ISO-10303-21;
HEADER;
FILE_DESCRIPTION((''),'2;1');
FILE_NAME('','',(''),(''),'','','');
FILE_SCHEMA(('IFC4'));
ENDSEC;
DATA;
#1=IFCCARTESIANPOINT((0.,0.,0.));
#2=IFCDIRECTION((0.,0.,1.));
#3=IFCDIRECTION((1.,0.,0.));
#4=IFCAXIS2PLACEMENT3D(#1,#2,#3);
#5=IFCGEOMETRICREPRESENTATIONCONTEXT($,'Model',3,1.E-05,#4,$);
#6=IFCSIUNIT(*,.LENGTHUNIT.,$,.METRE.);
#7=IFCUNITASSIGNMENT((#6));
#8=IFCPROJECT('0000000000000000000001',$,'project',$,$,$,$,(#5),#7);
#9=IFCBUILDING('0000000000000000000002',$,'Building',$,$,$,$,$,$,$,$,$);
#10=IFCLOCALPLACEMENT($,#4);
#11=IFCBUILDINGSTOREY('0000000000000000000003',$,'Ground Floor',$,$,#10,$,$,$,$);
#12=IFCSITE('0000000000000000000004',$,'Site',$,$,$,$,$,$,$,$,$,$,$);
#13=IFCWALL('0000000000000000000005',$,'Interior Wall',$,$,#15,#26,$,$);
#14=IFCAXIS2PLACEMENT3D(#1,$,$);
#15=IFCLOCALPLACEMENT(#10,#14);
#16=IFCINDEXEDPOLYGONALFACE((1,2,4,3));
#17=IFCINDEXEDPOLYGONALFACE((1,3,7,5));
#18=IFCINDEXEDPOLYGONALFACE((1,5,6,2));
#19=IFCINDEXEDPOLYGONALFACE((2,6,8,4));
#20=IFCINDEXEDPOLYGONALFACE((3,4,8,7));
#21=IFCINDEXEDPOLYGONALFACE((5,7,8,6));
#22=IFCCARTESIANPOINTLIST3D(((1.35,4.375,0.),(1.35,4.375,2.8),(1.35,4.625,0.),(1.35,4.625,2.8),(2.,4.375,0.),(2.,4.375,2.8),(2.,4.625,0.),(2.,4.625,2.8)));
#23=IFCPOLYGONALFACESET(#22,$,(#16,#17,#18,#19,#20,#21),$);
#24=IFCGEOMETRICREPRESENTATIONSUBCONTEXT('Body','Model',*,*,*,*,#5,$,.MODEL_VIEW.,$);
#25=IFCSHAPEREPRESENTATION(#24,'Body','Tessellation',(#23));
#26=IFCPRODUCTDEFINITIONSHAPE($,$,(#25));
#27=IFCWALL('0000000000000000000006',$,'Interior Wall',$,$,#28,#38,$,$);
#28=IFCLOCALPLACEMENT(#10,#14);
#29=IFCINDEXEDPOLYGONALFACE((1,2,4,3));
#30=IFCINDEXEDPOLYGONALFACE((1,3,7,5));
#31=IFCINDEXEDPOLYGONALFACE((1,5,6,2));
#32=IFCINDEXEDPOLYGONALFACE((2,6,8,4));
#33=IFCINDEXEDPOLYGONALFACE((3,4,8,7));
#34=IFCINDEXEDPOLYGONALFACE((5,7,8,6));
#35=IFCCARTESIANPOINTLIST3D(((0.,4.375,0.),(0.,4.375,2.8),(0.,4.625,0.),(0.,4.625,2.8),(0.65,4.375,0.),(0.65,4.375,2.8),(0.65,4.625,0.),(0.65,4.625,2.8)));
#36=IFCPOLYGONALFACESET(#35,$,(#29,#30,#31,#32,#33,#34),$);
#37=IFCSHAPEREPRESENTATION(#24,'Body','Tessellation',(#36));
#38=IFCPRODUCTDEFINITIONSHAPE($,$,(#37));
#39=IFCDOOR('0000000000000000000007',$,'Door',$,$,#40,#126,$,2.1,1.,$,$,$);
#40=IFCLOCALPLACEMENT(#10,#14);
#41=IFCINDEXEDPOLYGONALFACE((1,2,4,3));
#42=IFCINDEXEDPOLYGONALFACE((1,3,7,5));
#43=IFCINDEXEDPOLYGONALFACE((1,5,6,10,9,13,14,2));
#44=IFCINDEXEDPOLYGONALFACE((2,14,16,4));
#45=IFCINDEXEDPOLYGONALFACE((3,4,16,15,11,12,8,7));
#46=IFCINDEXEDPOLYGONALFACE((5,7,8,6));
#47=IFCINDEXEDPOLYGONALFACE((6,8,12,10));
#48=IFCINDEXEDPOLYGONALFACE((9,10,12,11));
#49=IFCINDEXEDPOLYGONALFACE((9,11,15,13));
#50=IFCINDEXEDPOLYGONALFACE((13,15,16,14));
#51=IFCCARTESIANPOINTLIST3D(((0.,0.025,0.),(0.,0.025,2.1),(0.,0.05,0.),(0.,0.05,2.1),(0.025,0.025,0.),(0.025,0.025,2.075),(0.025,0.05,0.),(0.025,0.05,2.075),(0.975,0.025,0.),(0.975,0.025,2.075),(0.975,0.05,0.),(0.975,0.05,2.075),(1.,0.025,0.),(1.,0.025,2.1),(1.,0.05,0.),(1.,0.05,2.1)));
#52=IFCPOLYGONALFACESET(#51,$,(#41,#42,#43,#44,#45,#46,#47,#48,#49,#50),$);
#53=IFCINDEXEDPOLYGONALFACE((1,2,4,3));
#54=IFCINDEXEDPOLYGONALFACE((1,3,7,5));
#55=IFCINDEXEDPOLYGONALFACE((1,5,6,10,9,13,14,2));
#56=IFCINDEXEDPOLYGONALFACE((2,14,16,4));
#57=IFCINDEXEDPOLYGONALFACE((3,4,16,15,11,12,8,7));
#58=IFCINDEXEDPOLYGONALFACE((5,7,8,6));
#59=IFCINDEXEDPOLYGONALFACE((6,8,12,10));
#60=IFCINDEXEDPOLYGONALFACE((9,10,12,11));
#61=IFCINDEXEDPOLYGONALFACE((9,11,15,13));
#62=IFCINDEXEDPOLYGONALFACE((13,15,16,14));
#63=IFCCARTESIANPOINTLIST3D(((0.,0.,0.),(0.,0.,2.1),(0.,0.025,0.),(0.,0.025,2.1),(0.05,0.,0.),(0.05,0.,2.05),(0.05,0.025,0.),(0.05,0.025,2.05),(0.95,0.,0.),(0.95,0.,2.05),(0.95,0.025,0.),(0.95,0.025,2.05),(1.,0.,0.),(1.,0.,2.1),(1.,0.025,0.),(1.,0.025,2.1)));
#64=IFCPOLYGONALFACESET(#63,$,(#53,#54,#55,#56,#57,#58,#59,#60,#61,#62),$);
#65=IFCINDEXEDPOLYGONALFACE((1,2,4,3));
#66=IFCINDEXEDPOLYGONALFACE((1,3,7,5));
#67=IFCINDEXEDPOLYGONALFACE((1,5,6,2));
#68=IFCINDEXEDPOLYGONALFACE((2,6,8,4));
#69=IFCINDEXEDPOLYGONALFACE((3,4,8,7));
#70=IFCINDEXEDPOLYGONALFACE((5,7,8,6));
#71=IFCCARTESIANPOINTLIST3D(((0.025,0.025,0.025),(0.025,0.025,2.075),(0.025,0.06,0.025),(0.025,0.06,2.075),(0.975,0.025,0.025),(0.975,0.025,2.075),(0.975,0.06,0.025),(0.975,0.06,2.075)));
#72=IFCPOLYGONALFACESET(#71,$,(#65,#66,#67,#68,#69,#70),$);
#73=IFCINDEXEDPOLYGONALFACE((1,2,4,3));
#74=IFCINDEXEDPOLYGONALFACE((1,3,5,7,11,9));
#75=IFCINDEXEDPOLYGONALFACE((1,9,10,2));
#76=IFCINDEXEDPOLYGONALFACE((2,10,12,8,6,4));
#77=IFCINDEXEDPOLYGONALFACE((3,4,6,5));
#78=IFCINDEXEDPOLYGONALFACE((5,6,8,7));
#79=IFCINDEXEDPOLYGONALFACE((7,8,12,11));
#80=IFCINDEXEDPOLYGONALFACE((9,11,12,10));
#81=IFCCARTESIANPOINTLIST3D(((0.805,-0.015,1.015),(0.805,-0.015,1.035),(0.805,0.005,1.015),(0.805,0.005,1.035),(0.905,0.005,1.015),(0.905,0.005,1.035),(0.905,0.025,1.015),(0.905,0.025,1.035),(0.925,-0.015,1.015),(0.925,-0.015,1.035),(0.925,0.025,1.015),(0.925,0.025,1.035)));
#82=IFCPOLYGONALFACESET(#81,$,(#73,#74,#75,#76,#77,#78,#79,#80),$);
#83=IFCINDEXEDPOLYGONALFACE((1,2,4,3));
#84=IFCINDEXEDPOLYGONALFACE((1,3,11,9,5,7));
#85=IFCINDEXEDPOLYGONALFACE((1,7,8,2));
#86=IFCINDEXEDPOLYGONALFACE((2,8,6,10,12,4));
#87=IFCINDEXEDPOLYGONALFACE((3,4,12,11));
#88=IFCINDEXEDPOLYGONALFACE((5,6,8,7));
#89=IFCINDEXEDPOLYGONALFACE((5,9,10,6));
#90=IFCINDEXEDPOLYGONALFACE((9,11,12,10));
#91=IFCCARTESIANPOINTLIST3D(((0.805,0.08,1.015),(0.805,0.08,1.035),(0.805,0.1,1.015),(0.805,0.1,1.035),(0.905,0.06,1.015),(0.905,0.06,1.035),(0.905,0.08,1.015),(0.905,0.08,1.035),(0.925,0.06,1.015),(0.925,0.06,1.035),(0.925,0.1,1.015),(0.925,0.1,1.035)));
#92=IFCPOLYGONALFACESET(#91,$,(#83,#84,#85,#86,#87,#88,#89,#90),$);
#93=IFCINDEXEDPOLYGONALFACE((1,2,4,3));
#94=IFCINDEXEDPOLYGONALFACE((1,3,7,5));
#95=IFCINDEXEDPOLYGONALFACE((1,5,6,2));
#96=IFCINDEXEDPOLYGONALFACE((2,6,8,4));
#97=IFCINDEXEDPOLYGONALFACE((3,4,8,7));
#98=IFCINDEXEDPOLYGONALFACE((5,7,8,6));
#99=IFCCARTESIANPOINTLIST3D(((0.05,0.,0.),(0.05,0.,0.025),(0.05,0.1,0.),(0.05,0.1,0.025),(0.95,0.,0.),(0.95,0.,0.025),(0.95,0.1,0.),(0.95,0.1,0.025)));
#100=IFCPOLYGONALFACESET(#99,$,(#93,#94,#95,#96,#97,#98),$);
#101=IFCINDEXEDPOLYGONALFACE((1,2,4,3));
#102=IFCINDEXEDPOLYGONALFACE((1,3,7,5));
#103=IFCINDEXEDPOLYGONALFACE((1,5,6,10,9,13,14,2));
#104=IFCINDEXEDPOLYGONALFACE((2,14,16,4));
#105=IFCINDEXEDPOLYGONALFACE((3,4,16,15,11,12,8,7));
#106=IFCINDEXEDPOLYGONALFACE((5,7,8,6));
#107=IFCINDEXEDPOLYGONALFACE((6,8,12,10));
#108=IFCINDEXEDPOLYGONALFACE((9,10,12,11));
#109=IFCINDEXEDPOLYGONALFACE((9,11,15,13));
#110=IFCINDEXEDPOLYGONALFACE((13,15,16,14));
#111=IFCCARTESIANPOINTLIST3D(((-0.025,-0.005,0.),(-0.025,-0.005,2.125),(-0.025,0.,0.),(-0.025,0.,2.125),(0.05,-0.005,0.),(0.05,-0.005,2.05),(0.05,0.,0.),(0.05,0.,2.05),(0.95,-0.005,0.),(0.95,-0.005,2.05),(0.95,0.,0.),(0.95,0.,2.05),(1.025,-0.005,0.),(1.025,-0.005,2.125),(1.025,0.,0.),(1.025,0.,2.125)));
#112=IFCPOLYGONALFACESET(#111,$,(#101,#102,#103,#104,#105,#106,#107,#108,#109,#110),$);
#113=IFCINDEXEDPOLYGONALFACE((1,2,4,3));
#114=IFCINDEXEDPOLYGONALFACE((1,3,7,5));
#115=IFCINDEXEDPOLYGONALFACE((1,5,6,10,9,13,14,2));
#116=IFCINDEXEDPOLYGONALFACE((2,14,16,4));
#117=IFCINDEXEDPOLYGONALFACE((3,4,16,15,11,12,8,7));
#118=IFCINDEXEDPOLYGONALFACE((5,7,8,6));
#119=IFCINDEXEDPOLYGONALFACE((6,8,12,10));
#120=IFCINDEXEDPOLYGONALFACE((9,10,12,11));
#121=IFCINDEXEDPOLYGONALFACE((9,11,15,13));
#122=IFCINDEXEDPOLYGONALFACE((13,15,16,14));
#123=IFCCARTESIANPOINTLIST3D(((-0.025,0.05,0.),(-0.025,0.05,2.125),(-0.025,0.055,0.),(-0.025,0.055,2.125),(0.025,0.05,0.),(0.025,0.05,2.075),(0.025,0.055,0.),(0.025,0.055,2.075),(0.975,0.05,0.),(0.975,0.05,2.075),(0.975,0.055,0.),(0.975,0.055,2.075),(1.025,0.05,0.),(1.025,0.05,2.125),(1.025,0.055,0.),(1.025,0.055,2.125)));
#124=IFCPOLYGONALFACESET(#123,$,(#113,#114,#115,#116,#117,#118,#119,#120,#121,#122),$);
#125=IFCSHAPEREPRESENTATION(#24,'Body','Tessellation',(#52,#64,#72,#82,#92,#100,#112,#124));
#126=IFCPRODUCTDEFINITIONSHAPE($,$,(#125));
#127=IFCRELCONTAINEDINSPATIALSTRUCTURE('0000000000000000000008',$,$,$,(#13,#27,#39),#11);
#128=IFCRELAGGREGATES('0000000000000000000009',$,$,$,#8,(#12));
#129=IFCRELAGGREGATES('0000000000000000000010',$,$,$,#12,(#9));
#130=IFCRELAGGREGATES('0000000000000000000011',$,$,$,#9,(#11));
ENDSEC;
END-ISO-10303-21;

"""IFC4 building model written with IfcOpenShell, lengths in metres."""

from ifc_helpers import new_model, si_unit, frame, origin_with_axes, place, context, subcontext, project, spatial, line, indexed_curve, outline, extrude, element, save


model = new_model("IFC4")

# Units and contexts
model_context = context("Model", 3, precision=1e-05, world=origin_with_axes())
body_context = subcontext(model_context, "Body", "Model", "MODEL_VIEW")
ifc_project = project(units=[si_unit("LENGTHUNIT", "METRE")], contexts=[model_context])

# Site, building, storey
site = spatial("IfcSite", under=ifc_project, Name="Site")
building = spatial("IfcBuilding", under=site, Name="Building")
storey_placement = place(None, origin_with_axes())
storey = spatial("IfcBuildingStorey", under=building, at=storey_placement, Name="Ground Floor")

# Walls
for number, where, z_axis, x_axis, name in (
    (1, (2.0, 4.5, 0.0), (0.0, 0.0, 1.0), (-1.0, 0.0, 0.0), "Interior Wall"),
    (2, (0.65, 4.5, 0.0), (0.0, 0.0, 1.0), (-1.0, 0.0, 0.0), "Interior Wall"),
):
    element("IfcWall", number, at=place(storey_placement, frame(where, z_axis=z_axis, x_axis=x_axis)), inside=storey, Name=name, context=body_context, shape_type="SweptSolid", body=[
        extrude(outline(indexed_curve([(0.0, 0.0), (0.0, 0.25), (0.65, 0.25), (0.65, 0.0), (0.0, 0.0)], self_intersect=False)), frame((0.0, -0.125, 0.0), z_axis=(0.0, 0.0, 1.0), x_axis=(1.0, 0.0, 0.0)), (0.0, 0.0, 1.0), 2.8),
    ])

# Door
door_1_placement = place(storey_placement, origin_with_axes())
element("IfcDoor", 3, at=door_1_placement, inside=storey, Name="Door", OverallHeight=2.1, OverallWidth=1.0, context=body_context, shape_type="SweptSolid", body=[
    extrude(outline(indexed_curve([(0.0, 0.0), (0.0, 2.1), (1.0, 2.1), (1.0, 0.0), (0.975, 0.0), (0.975, 2.075), (0.025, 2.075), (0.025, 0.0)], segments=[line(1, 2, 3, 4, 5, 6, 7, 8, 1)])), frame((0.0, 0.025, 0.0), z_axis=(0.0, -1.0, 0.0), x_axis=(1.0, 0.0, 0.0)), (0.0, 0.0, -1.0), 0.025),
    extrude(outline(indexed_curve([(0.0, 0.0), (0.0, 2.1), (1.0, 2.1), (1.0, 0.0), (0.95, 0.0), (0.95, 2.05), (0.05, 2.05), (0.05, 0.0)], segments=[line(1, 2, 3, 4, 5, 6, 7, 8, 1)])), frame((0.0, 0.0, 0.0), z_axis=(0.0, -1.0, 0.0), x_axis=(1.0, 0.0, 0.0)), (0.0, 0.0, -1.0), 0.025),
    extrude(outline(indexed_curve([(0.0, 0.0), (0.95, 0.0), (0.95, 0.035), (0.0, 0.035)], segments=[line(1, 2, 3, 4, 1)])), frame((0.025, 0.025, 0.025), z_axis=(0.0, 0.0, 1.0), x_axis=(1.0, 0.0, 0.0)), (0.0, 0.0, 1.0), 2.05),
    extrude(outline(indexed_curve([(0.0, 0.0), (0.0, -0.04), (-0.12, -0.04), (-0.12, -0.02), (-0.02, -0.02), (-0.02, 0.0)], segments=[line(1, 2, 3, 4, 5, 6, 1)])), frame((0.925, 0.025, 1.015), z_axis=(0.0, 0.0, 1.0), x_axis=(1.0, 0.0, 0.0)), (0.0, 0.0, 1.0), 0.02),
    extrude(outline(indexed_curve([(0.0, 0.0), (0.0, 0.04), (-0.12, 0.04), (-0.12, 0.02), (-0.02, 0.02), (-0.02, 0.0)], segments=[line(1, 2, 3, 4, 5, 6, 1)])), frame((0.925, 0.06, 1.015), z_axis=(0.0, 0.0, 1.0), x_axis=(1.0, 0.0, 0.0)), (0.0, 0.0, 1.0), 0.02),
    extrude(outline(indexed_curve([(0.0, 0.0), (0.9, 0.0), (0.9, 0.1), (0.0, 0.1)], segments=[line(1, 2, 3, 4, 1)])), frame((0.05, 0.0, 0.0), z_axis=(0.0, 0.0, 1.0), x_axis=(1.0, 0.0, 0.0)), (0.0, 0.0, 1.0), 0.025),
    extrude(outline(indexed_curve([(0.0, 0.0), (0.0, 2.125), (1.05, 2.125), (1.05, 0.0), (0.975, 0.0), (0.975, 2.05), (0.075, 2.05), (0.075, 0.0)], segments=[line(1, 2, 3, 4, 5, 6, 7, 8, 1)])), frame((-0.025, -0.005, 0.0), z_axis=(0.0, -1.0, 0.0), x_axis=(1.0, 0.0, 0.0)), (0.0, 0.0, -1.0), 0.005),
    extrude(outline(indexed_curve([(0.0, 0.0), (0.0, 2.125), (1.05, 2.125), (1.05, 0.0), (1.0, 0.0), (1.0, 2.075), (0.05, 2.075), (0.05, 0.0)], segments=[line(1, 2, 3, 4, 5, 6, 7, 8, 1)])), frame((-0.025, 0.05, 0.0), z_axis=(0.0, -1.0, 0.0), x_axis=(1.0, 0.0, 0.0)), (0.0, 0.0, -1.0), 0.005),
])

save(model, "model.ifc")
